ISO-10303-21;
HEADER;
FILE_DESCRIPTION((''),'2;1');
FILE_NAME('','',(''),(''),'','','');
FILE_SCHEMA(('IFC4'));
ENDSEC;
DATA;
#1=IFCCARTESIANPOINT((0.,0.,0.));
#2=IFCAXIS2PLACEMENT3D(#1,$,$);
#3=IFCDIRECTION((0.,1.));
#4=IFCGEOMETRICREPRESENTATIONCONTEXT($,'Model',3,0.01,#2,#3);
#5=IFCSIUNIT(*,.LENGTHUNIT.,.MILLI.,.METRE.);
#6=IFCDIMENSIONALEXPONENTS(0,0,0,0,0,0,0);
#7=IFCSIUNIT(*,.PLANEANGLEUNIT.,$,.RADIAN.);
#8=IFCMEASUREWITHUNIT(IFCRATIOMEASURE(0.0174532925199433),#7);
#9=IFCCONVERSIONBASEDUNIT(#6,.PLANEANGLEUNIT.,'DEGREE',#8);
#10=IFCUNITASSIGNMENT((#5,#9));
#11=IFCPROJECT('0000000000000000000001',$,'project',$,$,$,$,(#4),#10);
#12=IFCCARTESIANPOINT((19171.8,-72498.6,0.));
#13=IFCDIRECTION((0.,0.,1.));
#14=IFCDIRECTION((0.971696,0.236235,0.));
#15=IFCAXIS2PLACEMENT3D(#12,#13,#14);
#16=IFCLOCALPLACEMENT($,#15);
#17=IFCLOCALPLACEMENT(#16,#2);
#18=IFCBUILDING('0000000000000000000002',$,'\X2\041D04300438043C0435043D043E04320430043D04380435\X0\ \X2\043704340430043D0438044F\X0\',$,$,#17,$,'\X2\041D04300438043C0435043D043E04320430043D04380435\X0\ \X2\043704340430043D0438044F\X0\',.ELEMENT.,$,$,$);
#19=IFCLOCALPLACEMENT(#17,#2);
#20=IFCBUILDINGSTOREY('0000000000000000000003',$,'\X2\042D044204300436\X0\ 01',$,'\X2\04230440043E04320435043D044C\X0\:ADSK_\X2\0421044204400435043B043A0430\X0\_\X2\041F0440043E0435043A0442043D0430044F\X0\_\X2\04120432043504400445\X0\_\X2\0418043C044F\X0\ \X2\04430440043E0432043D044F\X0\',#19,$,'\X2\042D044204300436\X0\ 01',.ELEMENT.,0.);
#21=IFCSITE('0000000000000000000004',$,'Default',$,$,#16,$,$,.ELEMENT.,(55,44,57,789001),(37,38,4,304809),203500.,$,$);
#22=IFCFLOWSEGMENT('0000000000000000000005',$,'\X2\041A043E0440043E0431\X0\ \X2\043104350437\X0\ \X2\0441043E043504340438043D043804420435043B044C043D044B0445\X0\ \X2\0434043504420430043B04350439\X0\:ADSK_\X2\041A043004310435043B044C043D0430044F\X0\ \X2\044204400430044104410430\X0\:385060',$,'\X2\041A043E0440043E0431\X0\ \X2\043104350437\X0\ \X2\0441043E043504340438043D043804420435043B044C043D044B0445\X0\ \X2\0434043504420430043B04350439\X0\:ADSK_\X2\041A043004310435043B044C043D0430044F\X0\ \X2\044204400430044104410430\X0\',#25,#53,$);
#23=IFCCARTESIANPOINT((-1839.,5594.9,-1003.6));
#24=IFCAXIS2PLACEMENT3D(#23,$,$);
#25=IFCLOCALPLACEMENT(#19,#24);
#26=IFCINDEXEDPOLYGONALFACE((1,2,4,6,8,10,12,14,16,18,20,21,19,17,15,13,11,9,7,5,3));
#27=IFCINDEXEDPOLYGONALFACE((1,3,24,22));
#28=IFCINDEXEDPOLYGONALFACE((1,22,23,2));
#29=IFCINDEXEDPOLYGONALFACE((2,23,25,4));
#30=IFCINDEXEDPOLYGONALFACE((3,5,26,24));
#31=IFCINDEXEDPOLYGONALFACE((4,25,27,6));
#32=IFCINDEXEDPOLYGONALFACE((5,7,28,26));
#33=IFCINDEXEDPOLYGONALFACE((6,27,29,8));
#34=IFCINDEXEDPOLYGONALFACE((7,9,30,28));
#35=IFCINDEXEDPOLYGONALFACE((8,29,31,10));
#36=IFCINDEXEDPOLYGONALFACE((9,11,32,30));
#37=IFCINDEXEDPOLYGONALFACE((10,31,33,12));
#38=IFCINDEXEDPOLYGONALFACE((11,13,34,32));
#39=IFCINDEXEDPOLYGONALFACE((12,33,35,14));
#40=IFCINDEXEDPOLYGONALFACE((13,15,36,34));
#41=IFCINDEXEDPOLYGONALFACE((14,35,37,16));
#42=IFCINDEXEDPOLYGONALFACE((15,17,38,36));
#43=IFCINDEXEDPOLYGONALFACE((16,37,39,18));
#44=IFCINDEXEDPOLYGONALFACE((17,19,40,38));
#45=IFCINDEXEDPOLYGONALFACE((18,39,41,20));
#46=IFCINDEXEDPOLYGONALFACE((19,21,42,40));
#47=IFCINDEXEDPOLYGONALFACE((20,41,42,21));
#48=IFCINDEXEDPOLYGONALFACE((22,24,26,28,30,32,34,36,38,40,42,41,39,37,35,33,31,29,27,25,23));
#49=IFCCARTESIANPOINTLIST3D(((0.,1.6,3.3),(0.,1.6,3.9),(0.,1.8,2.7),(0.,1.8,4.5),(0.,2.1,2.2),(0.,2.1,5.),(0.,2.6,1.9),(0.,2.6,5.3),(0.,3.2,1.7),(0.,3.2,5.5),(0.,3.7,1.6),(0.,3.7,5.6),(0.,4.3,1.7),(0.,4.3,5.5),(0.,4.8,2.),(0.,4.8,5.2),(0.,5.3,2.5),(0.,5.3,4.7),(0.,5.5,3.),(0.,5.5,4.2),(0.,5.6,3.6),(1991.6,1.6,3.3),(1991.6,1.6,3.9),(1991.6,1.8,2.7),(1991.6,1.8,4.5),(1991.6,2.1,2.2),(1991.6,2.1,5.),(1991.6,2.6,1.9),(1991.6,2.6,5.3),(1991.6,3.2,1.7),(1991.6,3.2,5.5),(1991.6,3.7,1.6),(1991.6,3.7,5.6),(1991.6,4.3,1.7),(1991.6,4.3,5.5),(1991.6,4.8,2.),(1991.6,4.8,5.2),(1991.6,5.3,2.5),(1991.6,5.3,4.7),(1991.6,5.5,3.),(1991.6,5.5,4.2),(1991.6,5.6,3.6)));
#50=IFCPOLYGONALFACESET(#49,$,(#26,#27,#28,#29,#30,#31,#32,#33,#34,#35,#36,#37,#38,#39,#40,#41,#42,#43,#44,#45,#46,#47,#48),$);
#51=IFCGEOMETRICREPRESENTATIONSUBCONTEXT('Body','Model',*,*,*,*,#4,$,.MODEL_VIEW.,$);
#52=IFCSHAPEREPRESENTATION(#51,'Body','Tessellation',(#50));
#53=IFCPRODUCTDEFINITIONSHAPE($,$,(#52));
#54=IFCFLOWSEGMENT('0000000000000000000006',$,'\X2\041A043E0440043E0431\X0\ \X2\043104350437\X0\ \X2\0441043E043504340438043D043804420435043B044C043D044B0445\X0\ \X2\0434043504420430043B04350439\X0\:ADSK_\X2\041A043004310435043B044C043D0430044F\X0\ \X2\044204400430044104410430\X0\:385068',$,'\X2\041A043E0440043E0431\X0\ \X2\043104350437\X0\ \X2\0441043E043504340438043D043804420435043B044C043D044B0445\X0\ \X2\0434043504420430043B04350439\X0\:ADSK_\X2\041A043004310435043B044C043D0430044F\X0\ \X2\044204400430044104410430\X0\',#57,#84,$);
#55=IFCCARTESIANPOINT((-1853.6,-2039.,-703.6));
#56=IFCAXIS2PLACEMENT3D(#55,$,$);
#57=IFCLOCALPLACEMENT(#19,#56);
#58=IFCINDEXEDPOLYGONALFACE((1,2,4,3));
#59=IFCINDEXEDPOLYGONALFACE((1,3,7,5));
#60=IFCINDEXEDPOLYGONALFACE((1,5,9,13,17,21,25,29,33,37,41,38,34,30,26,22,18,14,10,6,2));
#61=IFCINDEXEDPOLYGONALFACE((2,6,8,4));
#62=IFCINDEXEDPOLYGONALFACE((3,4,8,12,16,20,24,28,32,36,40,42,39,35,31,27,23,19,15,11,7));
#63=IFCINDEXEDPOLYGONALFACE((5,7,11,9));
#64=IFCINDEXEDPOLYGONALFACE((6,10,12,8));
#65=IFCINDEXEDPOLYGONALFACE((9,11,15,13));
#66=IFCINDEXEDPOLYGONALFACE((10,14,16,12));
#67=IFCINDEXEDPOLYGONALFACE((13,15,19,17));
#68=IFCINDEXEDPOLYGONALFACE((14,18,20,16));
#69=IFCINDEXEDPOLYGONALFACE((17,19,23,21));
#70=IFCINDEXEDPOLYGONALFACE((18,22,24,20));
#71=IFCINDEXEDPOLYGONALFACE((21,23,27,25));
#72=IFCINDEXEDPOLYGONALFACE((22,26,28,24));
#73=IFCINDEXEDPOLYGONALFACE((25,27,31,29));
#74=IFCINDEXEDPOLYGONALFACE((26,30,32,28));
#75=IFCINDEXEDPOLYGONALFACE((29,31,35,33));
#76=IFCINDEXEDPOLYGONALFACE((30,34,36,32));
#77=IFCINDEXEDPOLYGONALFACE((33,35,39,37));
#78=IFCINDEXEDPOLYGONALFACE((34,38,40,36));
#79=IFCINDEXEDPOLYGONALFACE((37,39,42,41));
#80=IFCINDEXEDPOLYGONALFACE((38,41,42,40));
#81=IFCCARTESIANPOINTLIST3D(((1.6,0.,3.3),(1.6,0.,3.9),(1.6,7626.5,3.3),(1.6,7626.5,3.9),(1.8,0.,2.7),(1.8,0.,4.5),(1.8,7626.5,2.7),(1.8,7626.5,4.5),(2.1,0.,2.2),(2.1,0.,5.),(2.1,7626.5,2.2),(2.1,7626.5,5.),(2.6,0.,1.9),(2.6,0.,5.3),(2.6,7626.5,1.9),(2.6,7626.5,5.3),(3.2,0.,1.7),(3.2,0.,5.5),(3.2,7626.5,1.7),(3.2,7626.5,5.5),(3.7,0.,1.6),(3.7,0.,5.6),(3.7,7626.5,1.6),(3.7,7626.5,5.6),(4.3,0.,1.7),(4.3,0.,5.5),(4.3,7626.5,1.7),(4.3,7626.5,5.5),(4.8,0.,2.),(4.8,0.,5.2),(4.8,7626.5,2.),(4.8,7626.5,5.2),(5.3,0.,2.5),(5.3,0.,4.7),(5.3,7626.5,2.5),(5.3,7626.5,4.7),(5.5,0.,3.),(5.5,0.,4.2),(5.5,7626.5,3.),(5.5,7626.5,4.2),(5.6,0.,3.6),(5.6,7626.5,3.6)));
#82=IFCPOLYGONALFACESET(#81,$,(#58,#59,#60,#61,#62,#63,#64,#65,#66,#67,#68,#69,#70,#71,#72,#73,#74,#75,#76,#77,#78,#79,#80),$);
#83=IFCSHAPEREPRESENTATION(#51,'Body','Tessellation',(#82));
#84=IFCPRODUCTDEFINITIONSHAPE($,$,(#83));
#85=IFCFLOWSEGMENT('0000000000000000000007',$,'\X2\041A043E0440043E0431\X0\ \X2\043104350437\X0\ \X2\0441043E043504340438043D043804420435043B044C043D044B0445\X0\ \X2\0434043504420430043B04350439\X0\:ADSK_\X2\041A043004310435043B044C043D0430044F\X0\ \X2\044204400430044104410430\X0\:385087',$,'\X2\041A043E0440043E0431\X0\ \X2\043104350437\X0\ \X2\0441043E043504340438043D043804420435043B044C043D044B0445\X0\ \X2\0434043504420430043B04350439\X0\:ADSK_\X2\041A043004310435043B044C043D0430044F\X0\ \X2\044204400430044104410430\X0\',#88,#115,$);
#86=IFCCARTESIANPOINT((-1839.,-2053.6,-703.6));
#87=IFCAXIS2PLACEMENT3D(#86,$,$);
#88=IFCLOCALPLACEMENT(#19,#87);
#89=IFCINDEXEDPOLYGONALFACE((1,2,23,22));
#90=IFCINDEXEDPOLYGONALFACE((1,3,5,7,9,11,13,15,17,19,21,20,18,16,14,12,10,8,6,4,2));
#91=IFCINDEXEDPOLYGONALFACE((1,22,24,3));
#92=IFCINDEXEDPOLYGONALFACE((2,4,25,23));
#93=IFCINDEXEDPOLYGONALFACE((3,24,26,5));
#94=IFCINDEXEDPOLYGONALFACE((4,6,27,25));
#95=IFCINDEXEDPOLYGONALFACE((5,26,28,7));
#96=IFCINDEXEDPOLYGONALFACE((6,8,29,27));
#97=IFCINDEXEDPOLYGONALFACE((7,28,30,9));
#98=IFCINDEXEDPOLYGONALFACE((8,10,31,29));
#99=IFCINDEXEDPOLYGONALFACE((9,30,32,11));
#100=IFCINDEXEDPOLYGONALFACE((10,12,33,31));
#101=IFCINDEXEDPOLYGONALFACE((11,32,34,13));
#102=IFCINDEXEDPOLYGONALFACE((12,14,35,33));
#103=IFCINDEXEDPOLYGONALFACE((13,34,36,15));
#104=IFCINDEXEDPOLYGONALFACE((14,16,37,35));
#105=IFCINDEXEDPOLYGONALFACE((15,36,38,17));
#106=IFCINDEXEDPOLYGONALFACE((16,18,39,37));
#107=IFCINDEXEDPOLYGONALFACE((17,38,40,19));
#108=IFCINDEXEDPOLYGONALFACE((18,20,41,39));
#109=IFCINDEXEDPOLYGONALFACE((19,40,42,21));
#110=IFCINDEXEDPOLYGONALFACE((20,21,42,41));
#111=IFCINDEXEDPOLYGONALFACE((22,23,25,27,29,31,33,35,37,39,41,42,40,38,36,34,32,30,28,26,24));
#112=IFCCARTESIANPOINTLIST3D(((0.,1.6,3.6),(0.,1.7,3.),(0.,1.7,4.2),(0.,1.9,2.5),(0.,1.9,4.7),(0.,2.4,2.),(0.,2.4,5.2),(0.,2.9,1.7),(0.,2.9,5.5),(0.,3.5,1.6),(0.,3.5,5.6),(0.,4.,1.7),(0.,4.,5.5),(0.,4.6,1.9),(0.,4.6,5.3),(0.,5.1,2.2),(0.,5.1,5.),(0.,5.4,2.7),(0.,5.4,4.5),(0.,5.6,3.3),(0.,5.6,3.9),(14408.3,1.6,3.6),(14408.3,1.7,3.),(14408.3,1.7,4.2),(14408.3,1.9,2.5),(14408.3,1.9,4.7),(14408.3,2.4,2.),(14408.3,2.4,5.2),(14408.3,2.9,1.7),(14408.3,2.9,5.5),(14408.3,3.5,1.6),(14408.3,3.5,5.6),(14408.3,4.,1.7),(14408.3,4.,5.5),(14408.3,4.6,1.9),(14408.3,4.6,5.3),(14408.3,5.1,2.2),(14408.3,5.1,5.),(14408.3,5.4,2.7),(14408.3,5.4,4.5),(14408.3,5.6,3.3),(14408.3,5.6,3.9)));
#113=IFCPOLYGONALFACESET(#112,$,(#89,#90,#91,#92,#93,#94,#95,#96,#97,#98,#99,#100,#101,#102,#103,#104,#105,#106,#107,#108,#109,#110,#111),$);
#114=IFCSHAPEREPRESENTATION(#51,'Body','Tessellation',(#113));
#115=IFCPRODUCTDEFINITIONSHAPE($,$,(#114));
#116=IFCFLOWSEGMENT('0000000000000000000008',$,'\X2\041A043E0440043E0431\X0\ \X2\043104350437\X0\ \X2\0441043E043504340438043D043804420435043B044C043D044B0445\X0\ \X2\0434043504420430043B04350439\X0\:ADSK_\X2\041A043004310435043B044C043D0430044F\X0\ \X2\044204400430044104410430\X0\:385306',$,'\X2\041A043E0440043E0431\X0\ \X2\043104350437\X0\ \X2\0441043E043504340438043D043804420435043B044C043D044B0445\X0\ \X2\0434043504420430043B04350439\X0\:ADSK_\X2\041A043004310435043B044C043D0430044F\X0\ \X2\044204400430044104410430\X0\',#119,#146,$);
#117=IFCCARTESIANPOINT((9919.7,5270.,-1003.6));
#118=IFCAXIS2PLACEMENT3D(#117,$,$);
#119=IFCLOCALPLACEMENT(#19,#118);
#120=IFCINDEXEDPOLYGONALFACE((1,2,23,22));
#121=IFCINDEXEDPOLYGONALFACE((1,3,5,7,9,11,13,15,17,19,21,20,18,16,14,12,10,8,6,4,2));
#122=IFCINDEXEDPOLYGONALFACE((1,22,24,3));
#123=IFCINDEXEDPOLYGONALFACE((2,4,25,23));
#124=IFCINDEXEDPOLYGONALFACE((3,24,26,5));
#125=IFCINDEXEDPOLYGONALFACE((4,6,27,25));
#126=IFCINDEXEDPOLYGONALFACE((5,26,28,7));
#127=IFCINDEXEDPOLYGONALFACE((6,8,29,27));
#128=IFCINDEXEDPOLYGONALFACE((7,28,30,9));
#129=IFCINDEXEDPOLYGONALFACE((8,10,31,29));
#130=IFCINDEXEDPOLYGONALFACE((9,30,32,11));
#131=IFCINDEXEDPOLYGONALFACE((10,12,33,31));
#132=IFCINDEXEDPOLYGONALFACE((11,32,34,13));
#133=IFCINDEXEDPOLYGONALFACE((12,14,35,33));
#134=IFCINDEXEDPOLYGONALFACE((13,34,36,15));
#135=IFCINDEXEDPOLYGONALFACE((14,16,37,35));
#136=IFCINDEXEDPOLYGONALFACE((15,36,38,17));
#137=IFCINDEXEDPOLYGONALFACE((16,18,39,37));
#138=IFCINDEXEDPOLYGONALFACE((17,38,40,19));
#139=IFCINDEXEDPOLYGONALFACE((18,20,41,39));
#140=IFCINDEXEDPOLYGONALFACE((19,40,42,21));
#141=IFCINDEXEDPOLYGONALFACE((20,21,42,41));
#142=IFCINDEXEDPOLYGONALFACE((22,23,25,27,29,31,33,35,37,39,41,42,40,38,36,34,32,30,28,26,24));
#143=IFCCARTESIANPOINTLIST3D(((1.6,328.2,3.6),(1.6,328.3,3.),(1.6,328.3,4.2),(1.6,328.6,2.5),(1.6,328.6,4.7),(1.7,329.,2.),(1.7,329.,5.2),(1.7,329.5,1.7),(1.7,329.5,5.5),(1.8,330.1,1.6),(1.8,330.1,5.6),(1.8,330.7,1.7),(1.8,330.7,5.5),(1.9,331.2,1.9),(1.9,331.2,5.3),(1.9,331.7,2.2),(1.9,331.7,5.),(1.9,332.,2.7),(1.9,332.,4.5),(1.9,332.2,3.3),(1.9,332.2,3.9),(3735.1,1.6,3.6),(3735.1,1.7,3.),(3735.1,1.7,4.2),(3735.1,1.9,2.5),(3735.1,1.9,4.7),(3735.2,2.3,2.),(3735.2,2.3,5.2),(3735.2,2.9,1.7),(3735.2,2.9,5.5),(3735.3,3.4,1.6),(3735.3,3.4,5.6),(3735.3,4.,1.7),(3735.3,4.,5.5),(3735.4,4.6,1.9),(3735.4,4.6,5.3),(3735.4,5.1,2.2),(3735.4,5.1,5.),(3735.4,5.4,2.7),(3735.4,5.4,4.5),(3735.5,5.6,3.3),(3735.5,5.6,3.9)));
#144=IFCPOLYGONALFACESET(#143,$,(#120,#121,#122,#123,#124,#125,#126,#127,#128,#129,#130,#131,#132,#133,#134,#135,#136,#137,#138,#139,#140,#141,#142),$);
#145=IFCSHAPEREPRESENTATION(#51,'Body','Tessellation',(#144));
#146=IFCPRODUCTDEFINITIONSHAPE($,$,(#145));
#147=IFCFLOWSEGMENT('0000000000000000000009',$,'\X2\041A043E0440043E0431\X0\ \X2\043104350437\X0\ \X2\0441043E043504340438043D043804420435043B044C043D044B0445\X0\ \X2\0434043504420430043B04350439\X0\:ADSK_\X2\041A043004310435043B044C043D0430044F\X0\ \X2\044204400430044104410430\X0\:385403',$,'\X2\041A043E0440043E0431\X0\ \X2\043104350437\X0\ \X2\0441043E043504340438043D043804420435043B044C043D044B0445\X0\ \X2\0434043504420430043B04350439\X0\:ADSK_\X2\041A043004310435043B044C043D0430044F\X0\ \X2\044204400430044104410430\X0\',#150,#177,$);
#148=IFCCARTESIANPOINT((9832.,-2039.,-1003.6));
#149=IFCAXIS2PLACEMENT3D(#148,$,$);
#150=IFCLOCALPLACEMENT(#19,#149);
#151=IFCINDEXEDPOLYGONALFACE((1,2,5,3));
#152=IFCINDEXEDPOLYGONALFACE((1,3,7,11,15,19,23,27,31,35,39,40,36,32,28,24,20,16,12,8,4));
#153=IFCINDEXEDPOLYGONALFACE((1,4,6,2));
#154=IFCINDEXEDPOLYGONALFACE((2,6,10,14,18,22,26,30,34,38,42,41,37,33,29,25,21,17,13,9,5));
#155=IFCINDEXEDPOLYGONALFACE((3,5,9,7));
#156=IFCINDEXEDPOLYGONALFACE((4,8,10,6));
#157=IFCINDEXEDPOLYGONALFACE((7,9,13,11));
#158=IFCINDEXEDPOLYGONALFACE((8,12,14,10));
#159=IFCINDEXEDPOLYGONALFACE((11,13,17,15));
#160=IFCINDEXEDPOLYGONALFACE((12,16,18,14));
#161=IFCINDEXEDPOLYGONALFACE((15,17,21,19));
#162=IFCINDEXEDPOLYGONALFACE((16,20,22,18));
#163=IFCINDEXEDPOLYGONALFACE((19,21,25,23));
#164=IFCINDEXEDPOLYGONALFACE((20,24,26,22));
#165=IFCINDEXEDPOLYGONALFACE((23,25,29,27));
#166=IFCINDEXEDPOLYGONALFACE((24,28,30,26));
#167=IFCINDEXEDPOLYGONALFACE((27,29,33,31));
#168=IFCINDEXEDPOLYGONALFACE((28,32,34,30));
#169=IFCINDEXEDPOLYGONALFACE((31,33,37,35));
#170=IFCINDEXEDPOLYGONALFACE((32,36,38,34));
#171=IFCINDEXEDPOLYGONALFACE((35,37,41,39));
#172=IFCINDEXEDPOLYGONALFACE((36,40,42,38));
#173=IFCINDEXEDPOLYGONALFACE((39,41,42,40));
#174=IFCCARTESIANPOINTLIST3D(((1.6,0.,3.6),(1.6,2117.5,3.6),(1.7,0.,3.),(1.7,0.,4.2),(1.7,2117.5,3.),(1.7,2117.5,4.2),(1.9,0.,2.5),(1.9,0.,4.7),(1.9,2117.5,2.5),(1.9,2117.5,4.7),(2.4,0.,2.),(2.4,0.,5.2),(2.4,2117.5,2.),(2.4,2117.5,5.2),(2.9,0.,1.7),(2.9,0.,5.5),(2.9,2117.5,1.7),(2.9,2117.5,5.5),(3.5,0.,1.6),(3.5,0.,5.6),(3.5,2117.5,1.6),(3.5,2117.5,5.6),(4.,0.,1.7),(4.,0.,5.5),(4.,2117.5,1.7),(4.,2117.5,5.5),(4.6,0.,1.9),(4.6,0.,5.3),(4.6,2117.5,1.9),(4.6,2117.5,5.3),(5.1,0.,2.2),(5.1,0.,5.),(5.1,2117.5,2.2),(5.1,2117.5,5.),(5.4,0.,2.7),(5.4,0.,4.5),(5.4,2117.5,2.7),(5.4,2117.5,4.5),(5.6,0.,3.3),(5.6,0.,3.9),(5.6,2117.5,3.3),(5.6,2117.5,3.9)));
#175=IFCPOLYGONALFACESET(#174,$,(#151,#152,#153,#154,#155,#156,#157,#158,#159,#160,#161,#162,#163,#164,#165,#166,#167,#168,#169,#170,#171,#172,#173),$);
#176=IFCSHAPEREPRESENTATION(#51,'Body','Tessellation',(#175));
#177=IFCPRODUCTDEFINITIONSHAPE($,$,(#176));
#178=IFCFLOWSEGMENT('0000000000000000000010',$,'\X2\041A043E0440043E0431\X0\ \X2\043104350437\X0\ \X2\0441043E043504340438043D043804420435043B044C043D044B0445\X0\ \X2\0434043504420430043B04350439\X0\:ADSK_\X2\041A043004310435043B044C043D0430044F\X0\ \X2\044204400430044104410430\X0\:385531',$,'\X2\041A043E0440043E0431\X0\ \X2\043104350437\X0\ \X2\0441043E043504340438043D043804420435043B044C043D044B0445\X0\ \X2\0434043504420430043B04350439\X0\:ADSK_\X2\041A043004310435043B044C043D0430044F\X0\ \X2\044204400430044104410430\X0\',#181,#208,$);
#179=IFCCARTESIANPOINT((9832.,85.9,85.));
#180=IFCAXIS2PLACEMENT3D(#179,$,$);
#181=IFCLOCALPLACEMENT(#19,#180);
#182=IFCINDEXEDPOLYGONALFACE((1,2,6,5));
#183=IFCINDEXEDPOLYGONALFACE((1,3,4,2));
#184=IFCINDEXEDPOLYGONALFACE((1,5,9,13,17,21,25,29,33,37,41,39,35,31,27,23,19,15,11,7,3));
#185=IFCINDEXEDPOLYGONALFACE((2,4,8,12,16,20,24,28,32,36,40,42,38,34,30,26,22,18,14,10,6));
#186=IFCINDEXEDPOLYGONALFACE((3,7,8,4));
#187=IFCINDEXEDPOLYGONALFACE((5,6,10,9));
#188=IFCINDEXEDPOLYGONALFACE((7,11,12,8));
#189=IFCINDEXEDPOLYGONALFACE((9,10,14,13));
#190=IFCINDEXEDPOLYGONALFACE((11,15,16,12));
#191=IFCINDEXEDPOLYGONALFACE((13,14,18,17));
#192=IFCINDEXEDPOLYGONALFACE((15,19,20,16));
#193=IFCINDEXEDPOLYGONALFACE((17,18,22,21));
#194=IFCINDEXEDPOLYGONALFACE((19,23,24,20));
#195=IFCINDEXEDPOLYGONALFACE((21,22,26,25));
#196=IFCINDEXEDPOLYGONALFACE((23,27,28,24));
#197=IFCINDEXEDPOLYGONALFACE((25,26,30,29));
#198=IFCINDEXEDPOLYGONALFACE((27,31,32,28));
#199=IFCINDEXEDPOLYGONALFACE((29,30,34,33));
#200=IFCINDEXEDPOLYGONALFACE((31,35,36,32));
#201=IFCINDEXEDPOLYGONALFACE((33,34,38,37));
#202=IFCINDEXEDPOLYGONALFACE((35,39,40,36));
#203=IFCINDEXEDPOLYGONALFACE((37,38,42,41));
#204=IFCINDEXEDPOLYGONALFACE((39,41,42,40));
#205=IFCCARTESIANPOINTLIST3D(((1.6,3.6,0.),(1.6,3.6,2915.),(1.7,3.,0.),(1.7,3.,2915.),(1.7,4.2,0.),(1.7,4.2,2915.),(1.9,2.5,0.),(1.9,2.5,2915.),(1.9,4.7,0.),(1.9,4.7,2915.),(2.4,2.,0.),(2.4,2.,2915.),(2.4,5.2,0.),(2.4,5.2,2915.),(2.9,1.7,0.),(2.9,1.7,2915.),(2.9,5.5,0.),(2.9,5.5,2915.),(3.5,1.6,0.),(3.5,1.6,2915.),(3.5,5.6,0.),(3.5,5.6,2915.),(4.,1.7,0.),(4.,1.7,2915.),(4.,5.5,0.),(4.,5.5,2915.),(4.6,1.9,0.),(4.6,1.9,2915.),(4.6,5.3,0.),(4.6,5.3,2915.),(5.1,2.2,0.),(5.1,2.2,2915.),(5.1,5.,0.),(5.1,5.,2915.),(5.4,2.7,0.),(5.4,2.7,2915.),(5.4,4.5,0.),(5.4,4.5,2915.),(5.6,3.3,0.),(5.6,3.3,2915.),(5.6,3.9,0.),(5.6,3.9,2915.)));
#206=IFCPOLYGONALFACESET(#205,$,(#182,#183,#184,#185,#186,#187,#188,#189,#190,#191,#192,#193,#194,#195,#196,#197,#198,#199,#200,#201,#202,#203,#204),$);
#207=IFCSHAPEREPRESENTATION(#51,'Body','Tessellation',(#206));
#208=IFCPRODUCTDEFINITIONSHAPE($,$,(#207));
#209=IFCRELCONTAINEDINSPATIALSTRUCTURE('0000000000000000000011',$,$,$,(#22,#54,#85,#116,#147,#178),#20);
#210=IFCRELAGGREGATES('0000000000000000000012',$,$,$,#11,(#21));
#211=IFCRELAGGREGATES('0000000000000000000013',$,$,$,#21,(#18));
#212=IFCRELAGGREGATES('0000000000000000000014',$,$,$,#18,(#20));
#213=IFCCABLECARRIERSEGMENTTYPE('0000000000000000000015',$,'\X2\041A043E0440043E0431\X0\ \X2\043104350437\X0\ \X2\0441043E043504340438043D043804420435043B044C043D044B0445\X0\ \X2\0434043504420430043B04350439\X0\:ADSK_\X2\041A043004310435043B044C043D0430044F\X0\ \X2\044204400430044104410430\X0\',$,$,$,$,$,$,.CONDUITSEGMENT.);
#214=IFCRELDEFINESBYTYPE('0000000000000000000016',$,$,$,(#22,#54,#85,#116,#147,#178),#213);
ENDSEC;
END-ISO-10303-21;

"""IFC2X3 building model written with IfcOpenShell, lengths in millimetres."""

from ifc_helpers import new_model, entity, si_unit, converted_unit, direction, frame, origin, origin_2d_with_axis, place, context, subcontext, project, spatial, circle, extrude, type_object, element, save


model = new_model("IFC2X3")

# Units and contexts
model_context = context("Model", 3, precision=0.01, world=origin(), true_north=direction((0.0, 1.0)))
body_context = subcontext(model_context, "Body", "Model", "MODEL_VIEW")
ifc_project = project(units=[si_unit("LENGTHUNIT", "METRE", prefix="MILLI"), converted_unit("PLANEANGLEUNIT", "DEGREE", entity("IfcRatioMeasure", 0.0174532925199433), si_unit("PLANEANGLEUNIT", "RADIAN"), dimensions=[0, 0, 0, 0, 0, 0, 0])], contexts=[model_context])

# Site, building, storey
site_placement = place(None, frame((19171.8, -72498.6, 0.0), z_axis=(0.0, 0.0, 1.0), x_axis=(0.971696, 0.236235, 0.0)))
site = spatial("IfcSite", under=ifc_project, at=site_placement, Name="Default", CompositionType="ELEMENT", RefLatitude=(55, 44, 57, 789001), RefLongitude=(37, 38, 4, 304809), RefElevation=203500.0)
building_placement = place(site_placement, origin())
building = spatial("IfcBuilding", under=site, at=building_placement, Name="Наименование здания", LongName="Наименование здания", CompositionType="ELEMENT")
storey_placement = place(building_placement, origin())
storey = spatial("IfcBuildingStorey", under=building, at=storey_placement, Name="Этаж 01", ObjectType="Уровень:ADSK_Стрелка_Проектная_Вверх_Имя уровня", LongName="Этаж 01", CompositionType="ELEMENT", Elevation=0.0)

# Flow segments
cable_carrier_segment_type_1 = type_object("IfcCableCarrierSegmentType", Name="Короб без соединительных деталей:ADSK_Кабельная трасса", PredefinedType="CONDUITSEGMENT")
flow_segment_1_placement = place(storey_placement, frame((-1839.0, 5594.9, -1003.6)))
element("IfcFlowSegment", 1, at=flow_segment_1_placement, inside=storey, type_object=cable_carrier_segment_type_1, Name="Короб без соединительных деталей:ADSK_Кабельная трасса:385060", ObjectType="Короб без соединительных деталей:ADSK_Кабельная трасса", context=body_context, shape_type="SweptSolid", body=[
    extrude(circle(Radius=2.0, at=origin_2d_with_axis()), frame((0.0, 3.6, 3.6), z_axis=(1.0, 0.0, 0.0), x_axis=(0.0, 1.0, 0.0)), (0.0, 0.0, 1.0), 1991.6),
])
flow_segment_2_placement = place(storey_placement, frame((-1853.6, -2039.0, -703.6)))
element("IfcFlowSegment", 2, at=flow_segment_2_placement, inside=storey, type_object=cable_carrier_segment_type_1, Name="Короб без соединительных деталей:ADSK_Кабельная трасса:385068", ObjectType="Короб без соединительных деталей:ADSK_Кабельная трасса", context=body_context, shape_type="SweptSolid", body=[
    extrude(circle(Radius=2.0, at=origin_2d_with_axis()), frame((3.6, 0.0, 3.6), z_axis=(0.0, 1.0, 0.0), x_axis=(1.0, 0.0, 0.0)), (0.0, 0.0, 1.0), 7626.5),
])
flow_segment_3_placement = place(storey_placement, frame((-1839.0, -2053.6, -703.6)))
element("IfcFlowSegment", 3, at=flow_segment_3_placement, inside=storey, type_object=cable_carrier_segment_type_1, Name="Короб без соединительных деталей:ADSK_Кабельная трасса:385087", ObjectType="Короб без соединительных деталей:ADSK_Кабельная трасса", context=body_context, shape_type="SweptSolid", body=[
    extrude(circle(Radius=2.0, at=origin_2d_with_axis()), frame((0.0, 3.6, 3.6), z_axis=(1.0, 0.0, 0.0), x_axis=(0.0, -1.0, 0.0)), (0.0, 0.0, 1.0), 14408.3),
])
flow_segment_4_placement = place(storey_placement, frame((9919.7, 5270.0, -1003.6)))
element("IfcFlowSegment", 4, at=flow_segment_4_placement, inside=storey, type_object=cable_carrier_segment_type_1, Name="Короб без соединительных деталей:ADSK_Кабельная трасса:385306", ObjectType="Короб без соединительных деталей:ADSK_Кабельная трасса", context=body_context, shape_type="SweptSolid", body=[
    extrude(circle(Radius=2.0, at=origin_2d_with_axis()), frame((3735.3, 3.6, 3.6), z_axis=(-0.996195, 0.087156, 0.0), x_axis=(-0.087156, -0.996195, 0.0)), (0.0, 0.0, 1.0), 3747.8),
])
flow_segment_5_placement = place(storey_placement, frame((9832.0, -2039.0, -1003.6)))
element("IfcFlowSegment", 5, at=flow_segment_5_placement, inside=storey, type_object=cable_carrier_segment_type_1, Name="Короб без соединительных деталей:ADSK_Кабельная трасса:385403", ObjectType="Короб без соединительных деталей:ADSK_Кабельная трасса", context=body_context, shape_type="SweptSolid", body=[
    extrude(circle(Radius=2.0, at=origin_2d_with_axis()), frame((3.6, 0.0, 3.6), z_axis=(0.0, 1.0, 0.0), x_axis=(-1.0, 0.0, 0.0)), (0.0, 0.0, 1.0), 2117.5),
])
flow_segment_6_placement = place(storey_placement, frame((9832.0, 85.9, 85.0)))
element("IfcFlowSegment", 6, at=flow_segment_6_placement, inside=storey, type_object=cable_carrier_segment_type_1, Name="Короб без соединительных деталей:ADSK_Кабельная трасса:385531", ObjectType="Короб без соединительных деталей:ADSK_Кабельная трасса", context=body_context, shape_type="SweptSolid", body=[
    extrude(circle(Radius=2.0, at=origin_2d_with_axis()), frame((3.6, 3.6, 0.0), z_axis=(0.0, 0.0, 1.0), x_axis=(-1.0, 0.0, 0.0)), (0.0, 0.0, 1.0), 2915.0),
])

save(model, "model.ifc")
